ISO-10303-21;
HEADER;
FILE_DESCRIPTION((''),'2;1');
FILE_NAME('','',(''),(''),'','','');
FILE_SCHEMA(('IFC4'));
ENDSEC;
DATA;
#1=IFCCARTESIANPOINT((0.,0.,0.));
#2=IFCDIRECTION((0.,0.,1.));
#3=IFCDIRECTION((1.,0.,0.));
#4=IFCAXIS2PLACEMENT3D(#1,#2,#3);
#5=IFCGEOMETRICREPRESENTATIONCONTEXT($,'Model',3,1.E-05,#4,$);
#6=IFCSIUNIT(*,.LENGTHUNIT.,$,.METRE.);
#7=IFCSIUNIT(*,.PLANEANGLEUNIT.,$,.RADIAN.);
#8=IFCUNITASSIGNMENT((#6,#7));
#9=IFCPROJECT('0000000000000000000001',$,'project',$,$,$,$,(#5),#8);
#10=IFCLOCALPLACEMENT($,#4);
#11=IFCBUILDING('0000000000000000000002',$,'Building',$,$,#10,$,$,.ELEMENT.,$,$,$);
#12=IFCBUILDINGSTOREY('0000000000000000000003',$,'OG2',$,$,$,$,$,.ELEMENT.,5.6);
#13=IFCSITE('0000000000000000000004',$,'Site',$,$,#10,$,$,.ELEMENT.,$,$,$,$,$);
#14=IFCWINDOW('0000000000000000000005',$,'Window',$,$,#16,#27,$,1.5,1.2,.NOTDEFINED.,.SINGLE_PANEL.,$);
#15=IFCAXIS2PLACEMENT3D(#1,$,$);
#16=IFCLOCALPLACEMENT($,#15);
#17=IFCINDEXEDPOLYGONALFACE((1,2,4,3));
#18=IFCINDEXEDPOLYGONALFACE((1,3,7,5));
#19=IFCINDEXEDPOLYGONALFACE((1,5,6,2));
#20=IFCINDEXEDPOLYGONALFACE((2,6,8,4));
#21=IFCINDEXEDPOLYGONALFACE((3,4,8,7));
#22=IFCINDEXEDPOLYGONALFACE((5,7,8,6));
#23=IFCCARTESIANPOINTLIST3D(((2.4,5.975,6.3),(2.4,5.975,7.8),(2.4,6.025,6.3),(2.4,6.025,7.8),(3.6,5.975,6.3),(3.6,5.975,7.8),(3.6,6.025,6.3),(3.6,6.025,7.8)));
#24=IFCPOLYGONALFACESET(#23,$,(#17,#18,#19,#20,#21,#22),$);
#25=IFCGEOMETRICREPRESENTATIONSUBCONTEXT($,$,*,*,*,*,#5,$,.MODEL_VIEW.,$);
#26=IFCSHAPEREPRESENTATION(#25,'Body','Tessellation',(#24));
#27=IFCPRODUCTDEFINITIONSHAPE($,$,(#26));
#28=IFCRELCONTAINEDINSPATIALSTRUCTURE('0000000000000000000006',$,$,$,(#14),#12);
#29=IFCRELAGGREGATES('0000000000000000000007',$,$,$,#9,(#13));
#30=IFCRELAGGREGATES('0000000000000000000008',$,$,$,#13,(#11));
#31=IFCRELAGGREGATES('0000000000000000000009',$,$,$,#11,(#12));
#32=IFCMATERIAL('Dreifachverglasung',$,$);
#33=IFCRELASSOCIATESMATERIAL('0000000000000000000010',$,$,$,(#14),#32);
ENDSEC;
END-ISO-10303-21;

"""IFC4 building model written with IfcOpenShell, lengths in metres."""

from ifc_helpers import new_model, si_unit, frame, origin, origin_with_axes, origin_2d, place, context, subcontext, project, spatial, rectangle, extrude, material, element, save


model = new_model("IFC4")

# Units and contexts
model_context = context("Model", 3, precision=1e-05, world=origin_with_axes())
sub_context = subcontext(model_context, None, None, "MODEL_VIEW")
ifc_project = project(units=[si_unit("LENGTHUNIT", "METRE"), si_unit("PLANEANGLEUNIT", "RADIAN")], contexts=[model_context])

# Site, building, storey
placement_1 = place(None, origin_with_axes())
site = spatial("IfcSite", under=ifc_project, at=placement_1, Name="Site", CompositionType="ELEMENT")
building = spatial("IfcBuilding", under=site, at=placement_1, Name="Building", CompositionType="ELEMENT")
storey = spatial("IfcBuildingStorey", under=building, Name="OG2", CompositionType="ELEMENT", Elevation=5.6)

# Window
ifc_material = material(Name="Dreifachverglasung")
placement_2 = place(None, origin_with_axes())
window_placement = place(placement_2, frame((3.0, 6.0, 6.3)))
element("IfcWindow", 1, at=window_placement, inside=storey, material=ifc_material, Name="Window", OverallHeight=1.5, OverallWidth=1.2, PartitioningType="SINGLE_PANEL", PredefinedType="NOTDEFINED", context=sub_context, shape_type="SweptSolid", body=[
    extrude(rectangle(XDim=1.2, YDim=0.05, at=origin_2d()), origin(), (0.0, 0.0, 1.0), 1.5),
])

save(model, "model.ifc")
